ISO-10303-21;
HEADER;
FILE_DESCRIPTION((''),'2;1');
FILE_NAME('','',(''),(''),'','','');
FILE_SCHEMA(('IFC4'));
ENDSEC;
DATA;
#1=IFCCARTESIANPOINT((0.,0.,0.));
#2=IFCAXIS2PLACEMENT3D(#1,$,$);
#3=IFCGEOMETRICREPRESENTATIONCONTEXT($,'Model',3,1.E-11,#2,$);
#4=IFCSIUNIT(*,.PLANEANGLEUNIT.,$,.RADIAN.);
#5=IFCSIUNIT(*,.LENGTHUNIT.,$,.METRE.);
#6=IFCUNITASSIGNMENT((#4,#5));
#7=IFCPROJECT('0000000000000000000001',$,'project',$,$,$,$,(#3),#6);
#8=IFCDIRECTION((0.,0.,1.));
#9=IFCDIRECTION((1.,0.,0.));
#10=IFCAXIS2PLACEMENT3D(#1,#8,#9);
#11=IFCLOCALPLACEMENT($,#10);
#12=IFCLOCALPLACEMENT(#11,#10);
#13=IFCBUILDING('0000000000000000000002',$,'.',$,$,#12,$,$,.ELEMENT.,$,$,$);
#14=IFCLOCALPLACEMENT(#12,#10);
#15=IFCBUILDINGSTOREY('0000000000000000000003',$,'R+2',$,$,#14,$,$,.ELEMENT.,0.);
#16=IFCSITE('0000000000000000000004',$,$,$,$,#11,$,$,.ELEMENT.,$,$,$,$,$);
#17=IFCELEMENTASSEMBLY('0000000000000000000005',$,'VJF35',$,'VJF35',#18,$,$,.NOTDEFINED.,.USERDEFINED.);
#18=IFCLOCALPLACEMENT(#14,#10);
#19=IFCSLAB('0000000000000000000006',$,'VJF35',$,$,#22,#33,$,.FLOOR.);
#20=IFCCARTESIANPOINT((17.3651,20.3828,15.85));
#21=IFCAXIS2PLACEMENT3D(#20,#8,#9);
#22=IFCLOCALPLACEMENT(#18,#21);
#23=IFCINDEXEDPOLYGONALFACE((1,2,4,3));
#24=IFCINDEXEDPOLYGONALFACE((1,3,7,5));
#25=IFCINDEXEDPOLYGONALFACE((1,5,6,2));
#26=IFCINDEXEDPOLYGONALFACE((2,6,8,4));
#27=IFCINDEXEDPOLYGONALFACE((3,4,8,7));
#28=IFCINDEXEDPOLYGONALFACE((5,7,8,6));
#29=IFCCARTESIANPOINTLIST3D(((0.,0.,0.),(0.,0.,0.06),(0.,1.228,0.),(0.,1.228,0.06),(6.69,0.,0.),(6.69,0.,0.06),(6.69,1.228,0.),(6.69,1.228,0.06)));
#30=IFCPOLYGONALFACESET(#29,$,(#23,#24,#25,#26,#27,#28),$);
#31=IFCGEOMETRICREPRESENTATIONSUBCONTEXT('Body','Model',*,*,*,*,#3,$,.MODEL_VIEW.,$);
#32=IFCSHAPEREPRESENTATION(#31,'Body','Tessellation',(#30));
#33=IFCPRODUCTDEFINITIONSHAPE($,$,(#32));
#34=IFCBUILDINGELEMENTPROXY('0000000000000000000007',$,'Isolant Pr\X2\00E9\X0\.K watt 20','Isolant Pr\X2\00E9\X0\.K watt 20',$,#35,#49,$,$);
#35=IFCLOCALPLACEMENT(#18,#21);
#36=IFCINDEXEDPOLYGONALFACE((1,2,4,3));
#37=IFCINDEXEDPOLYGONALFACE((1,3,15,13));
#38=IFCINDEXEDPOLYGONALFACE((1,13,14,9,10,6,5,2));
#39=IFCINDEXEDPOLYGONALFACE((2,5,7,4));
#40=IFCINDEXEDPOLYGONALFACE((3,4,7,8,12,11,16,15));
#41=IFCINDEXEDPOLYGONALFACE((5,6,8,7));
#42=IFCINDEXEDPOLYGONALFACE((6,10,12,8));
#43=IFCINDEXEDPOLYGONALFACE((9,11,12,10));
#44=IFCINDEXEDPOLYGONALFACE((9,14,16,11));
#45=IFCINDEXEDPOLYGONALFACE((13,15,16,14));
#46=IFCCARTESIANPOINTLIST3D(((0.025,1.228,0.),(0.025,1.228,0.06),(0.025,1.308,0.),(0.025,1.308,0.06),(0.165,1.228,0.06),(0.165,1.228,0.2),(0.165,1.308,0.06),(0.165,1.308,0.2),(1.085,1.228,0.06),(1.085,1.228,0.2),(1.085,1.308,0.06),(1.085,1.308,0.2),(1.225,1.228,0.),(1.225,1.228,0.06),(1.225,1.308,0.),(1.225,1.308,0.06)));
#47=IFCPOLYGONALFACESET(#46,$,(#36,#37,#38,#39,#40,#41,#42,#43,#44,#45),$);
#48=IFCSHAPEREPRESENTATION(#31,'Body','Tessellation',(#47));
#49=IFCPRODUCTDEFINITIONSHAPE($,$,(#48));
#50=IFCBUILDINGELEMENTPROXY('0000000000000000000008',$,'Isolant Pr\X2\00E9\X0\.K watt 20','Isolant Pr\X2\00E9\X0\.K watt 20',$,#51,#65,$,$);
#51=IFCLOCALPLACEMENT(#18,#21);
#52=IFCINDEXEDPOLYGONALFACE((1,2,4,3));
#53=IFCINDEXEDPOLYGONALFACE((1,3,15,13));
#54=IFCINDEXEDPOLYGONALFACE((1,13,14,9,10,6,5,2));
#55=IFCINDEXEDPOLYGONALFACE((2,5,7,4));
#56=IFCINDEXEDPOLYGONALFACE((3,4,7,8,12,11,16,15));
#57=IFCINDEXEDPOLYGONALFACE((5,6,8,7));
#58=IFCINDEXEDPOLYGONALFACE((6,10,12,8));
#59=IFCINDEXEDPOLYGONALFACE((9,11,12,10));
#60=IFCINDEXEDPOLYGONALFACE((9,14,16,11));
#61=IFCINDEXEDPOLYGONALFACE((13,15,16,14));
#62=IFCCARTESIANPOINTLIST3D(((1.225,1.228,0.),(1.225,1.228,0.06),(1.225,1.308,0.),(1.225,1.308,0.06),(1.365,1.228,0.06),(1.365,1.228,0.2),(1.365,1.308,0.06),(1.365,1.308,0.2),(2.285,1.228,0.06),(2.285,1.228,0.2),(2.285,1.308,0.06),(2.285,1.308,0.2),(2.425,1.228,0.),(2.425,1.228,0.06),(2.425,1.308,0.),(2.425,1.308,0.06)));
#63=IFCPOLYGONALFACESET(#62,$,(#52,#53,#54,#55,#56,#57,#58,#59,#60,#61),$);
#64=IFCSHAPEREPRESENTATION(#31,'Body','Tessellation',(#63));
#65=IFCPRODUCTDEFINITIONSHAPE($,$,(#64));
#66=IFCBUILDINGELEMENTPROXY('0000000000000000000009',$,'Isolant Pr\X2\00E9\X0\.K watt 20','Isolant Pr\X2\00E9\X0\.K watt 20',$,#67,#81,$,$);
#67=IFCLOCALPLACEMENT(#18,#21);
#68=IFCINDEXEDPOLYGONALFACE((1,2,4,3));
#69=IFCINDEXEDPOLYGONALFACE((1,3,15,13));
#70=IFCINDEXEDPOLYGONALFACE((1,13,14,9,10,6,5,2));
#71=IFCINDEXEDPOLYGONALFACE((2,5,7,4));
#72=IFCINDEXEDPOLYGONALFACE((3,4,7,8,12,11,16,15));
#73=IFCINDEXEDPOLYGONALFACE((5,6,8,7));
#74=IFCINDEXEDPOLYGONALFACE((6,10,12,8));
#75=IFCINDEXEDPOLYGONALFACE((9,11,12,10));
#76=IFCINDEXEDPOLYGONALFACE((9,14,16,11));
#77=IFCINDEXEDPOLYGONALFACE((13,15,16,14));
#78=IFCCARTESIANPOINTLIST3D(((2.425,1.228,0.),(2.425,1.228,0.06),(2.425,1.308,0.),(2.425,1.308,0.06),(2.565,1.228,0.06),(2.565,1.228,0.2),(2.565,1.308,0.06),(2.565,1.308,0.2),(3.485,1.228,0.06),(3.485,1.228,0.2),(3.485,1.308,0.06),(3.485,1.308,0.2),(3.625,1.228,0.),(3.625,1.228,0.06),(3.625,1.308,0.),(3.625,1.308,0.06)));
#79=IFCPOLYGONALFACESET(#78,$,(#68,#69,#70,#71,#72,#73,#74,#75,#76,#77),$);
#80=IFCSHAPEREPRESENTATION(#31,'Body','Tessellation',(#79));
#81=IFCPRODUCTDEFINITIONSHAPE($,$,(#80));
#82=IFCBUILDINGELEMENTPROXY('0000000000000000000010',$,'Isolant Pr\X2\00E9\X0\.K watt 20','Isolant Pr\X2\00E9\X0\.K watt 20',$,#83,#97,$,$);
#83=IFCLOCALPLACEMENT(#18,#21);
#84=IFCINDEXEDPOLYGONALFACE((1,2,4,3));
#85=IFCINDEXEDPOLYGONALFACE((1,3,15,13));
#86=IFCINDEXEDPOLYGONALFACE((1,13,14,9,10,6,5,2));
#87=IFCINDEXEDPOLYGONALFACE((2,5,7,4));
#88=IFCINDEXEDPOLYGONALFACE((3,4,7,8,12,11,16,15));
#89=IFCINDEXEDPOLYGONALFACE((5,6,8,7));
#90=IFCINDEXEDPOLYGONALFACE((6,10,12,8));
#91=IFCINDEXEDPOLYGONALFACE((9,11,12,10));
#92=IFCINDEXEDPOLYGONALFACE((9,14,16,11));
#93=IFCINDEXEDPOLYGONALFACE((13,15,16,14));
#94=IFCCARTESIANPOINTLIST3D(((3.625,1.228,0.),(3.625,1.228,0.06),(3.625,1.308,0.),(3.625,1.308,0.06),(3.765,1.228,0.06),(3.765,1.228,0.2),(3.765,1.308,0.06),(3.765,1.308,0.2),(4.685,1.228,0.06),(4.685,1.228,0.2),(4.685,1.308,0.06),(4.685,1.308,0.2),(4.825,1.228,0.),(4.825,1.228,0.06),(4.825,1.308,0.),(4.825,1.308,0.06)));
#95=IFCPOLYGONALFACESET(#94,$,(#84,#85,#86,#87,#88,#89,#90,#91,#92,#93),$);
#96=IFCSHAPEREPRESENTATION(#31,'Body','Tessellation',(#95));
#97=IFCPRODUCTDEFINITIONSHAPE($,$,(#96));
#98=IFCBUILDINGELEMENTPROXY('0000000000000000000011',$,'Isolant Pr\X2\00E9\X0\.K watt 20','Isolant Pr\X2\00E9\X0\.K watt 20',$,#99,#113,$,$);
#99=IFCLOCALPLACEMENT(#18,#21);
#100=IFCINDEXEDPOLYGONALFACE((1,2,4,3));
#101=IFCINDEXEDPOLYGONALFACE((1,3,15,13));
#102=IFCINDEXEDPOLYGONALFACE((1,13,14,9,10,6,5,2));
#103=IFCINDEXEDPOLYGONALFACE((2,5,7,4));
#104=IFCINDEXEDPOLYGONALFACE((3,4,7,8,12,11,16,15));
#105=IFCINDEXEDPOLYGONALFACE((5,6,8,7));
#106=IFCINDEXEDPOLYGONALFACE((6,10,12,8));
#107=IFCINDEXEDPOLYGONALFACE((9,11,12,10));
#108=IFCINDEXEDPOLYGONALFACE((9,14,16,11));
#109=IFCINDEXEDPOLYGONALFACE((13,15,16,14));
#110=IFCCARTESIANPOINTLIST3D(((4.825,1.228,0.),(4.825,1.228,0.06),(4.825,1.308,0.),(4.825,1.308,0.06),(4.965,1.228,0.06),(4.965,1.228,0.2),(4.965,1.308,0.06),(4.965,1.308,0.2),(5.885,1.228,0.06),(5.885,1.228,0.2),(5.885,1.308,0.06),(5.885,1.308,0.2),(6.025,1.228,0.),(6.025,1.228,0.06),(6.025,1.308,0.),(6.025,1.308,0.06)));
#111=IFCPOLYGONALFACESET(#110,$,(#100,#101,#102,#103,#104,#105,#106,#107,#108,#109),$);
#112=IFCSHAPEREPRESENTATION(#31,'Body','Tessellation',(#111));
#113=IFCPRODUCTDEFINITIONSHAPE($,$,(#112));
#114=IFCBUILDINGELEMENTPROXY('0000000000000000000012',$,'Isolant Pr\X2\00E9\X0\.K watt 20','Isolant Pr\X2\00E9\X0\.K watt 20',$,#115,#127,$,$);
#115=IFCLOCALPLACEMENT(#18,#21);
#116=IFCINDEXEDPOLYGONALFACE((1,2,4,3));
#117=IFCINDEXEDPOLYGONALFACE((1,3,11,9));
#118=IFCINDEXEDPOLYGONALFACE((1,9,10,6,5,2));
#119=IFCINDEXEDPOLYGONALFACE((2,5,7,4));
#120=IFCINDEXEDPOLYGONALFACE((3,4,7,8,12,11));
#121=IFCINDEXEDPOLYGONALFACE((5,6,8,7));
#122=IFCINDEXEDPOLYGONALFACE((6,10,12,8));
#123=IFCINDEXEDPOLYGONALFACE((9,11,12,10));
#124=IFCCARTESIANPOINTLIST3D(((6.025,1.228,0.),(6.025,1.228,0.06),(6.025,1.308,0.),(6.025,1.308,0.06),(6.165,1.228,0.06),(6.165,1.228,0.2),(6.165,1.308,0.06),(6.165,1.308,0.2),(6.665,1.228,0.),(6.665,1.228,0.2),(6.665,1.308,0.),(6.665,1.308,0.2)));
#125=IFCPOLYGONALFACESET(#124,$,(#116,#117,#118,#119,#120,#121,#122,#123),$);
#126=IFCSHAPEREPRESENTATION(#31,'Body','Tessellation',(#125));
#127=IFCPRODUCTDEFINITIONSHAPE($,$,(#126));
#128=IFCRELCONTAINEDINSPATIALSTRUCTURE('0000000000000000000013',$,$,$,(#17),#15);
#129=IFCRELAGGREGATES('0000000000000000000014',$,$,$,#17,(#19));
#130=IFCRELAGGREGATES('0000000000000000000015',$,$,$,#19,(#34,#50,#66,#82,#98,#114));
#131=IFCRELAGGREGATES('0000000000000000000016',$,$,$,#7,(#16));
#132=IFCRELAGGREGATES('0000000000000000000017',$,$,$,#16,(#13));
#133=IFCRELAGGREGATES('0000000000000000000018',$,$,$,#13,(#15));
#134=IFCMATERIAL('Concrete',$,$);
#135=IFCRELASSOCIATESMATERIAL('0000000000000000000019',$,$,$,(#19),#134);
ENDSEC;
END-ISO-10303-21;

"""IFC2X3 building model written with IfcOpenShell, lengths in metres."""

from ifc_helpers import new_model, si_unit, frame, origin, origin_with_axes, place, context, subcontext, project, spatial, polyline, outline, extrude, material, element, aggregate, save


model = new_model("IFC2X3")

# Units and contexts
model_context = context("Model", 3, precision=1e-11, world=origin())
body_context = subcontext(model_context, "Body", "Model", "MODEL_VIEW")
ifc_project = project(units=[si_unit("PLANEANGLEUNIT", "RADIAN"), si_unit("LENGTHUNIT", "METRE")], contexts=[model_context])

# Site, building, storey
site_placement = place(None, origin_with_axes())
site = spatial("IfcSite", under=ifc_project, at=site_placement, CompositionType="ELEMENT")
building_placement = place(site_placement, origin_with_axes())
building = spatial("IfcBuilding", under=site, at=building_placement, Name=".", CompositionType="ELEMENT")
storey_placement = place(building_placement, origin_with_axes())
storey = spatial("IfcBuildingStorey", under=building, at=storey_placement, Name="R+2", CompositionType="ELEMENT", Elevation=0.0)

# Shared definitions
ifc_material = material(Name="Concrete")

# Element assembly, slab
assembly_1_placement = place(storey_placement, origin_with_axes())
assembly_1 = element("IfcElementAssembly", 1, at=assembly_1_placement, inside=storey, Name="VJF35", ObjectType="VJF35", AssemblyPlace="NOTDEFINED", PredefinedType="USERDEFINED")
slab_1_placement = place(assembly_1_placement, frame((17.3651, 20.3828, 15.85), z_axis=(0.0, 0.0, 1.0), x_axis=(1.0, 0.0, 0.0)))
slab_1 = element("IfcSlab", 2, at=slab_1_placement, material=ifc_material, Name="VJF35", PredefinedType="FLOOR", context=body_context, shape_type="SweptSolid", body=[
    extrude(outline(polyline([(0.0, 0.0), (0.0, -6.69), (1.228, -6.69), (1.228, 0.0), (0.0, 0.0)])), frame((0.0, 0.0, 0.0), z_axis=(0.0, 0.0, 1.0), x_axis=(0.0, 1.0, 0.0)), (0.0, 0.0, 1.0), 0.06),
])
aggregate(assembly_1, [slab_1])

# Building element proxies, openings
proxy_1_placement = place(assembly_1_placement, frame((17.3651, 20.3828, 15.85), z_axis=(0.0, 0.0, 1.0), x_axis=(1.0, 0.0, 0.0)))
proxy_1 = element("IfcBuildingElementProxy", 3, at=proxy_1_placement, Name="Isolant Pré.K watt 20", Description="Isolant Pré.K watt 20", context=body_context, shape_type="SweptSolid", body=[
    extrude(outline(polyline([(1.228, -0.025), (1.228, -1.225), (1.308, -1.225), (1.308, -0.025), (1.228, -0.025)])), frame((0.0, 0.0, 0.0), z_axis=(0.0, 0.0, 1.0), x_axis=(0.0, 1.0, 0.0)), (0.0, 0.0, 1.0), 0.2),
])
opening_1_placement = place(proxy_1_placement, frame((0.025, 1.228, 0.06), z_axis=(0.0, 0.0, 1.0), x_axis=(1.0, 0.0, 0.0)))
element("IfcOpeningElement", 4, at=opening_1_placement, cuts=proxy_1, context=body_context, shape_type="SweptSolid", body=[
    extrude(outline(polyline([(0.0, 0.0), (0.0, -0.14), (0.08, -0.14), (0.08, 0.0), (0.0, 0.0)])), frame((0.0, 0.0, 0.0), z_axis=(0.0, 0.0, 1.0), x_axis=(0.0, 1.0, 0.0)), (0.0, 0.0, 1.0), 0.14),
])
opening_2_placement = place(proxy_1_placement, frame((1.225, 1.308, 0.06), z_axis=(0.0, 0.0, 1.0), x_axis=(-1.0, 0.0, 0.0)))
element("IfcOpeningElement", 5, at=opening_2_placement, cuts=proxy_1, context=body_context, shape_type="SweptSolid", body=[
    extrude(outline(polyline([(0.0, 0.0), (0.0, -0.14), (0.08, -0.14), (0.08, 0.0), (0.0, 0.0)])), frame((0.0, 0.0, 0.0), z_axis=(0.0, 0.0, 1.0), x_axis=(0.0, 1.0, 0.0)), (0.0, 0.0, 1.0), 0.14),
])
proxy_2_placement = place(assembly_1_placement, frame((17.3651, 20.3828, 15.85), z_axis=(0.0, 0.0, 1.0), x_axis=(1.0, 0.0, 0.0)))
proxy_2 = element("IfcBuildingElementProxy", 6, at=proxy_2_placement, Name="Isolant Pré.K watt 20", Description="Isolant Pré.K watt 20", context=body_context, shape_type="SweptSolid", body=[
    extrude(outline(polyline([(1.228, -1.225), (1.228, -2.425), (1.308, -2.425), (1.308, -1.225), (1.228, -1.225)])), frame((0.0, 0.0, 0.0), z_axis=(0.0, 0.0, 1.0), x_axis=(0.0, 1.0, 0.0)), (0.0, 0.0, 1.0), 0.2),
])
opening_3_placement = place(proxy_2_placement, frame((1.225, 1.228, 0.06), z_axis=(0.0, 0.0, 1.0), x_axis=(1.0, 0.0, 0.0)))
element("IfcOpeningElement", 7, at=opening_3_placement, cuts=proxy_2, context=body_context, shape_type="SweptSolid", body=[
    extrude(outline(polyline([(0.0, 0.0), (0.0, -0.14), (0.08, -0.14), (0.08, 0.0), (0.0, 0.0)])), frame((0.0, 0.0, 0.0), z_axis=(0.0, 0.0, 1.0), x_axis=(0.0, 1.0, 0.0)), (0.0, 0.0, 1.0), 0.14),
])
opening_4_placement = place(proxy_2_placement, frame((2.425, 1.308, 0.06), z_axis=(0.0, 0.0, 1.0), x_axis=(-1.0, 0.0, 0.0)))
element("IfcOpeningElement", 8, at=opening_4_placement, cuts=proxy_2, context=body_context, shape_type="SweptSolid", body=[
    extrude(outline(polyline([(0.0, 0.0), (0.0, -0.14), (0.08, -0.14), (0.08, 0.0), (0.0, 0.0)])), frame((0.0, 0.0, 0.0), z_axis=(0.0, 0.0, 1.0), x_axis=(0.0, 1.0, 0.0)), (0.0, 0.0, 1.0), 0.14),
])
proxy_3_placement = place(assembly_1_placement, frame((17.3651, 20.3828, 15.85), z_axis=(0.0, 0.0, 1.0), x_axis=(1.0, 0.0, 0.0)))
proxy_3 = element("IfcBuildingElementProxy", 9, at=proxy_3_placement, Name="Isolant Pré.K watt 20", Description="Isolant Pré.K watt 20", context=body_context, shape_type="SweptSolid", body=[
    extrude(outline(polyline([(1.228, -2.425), (1.228, -3.625), (1.308, -3.625), (1.308, -2.425), (1.228, -2.425)])), frame((0.0, 0.0, 0.0), z_axis=(0.0, 0.0, 1.0), x_axis=(0.0, 1.0, 0.0)), (0.0, 0.0, 1.0), 0.2),
])
opening_5_placement = place(proxy_3_placement, frame((2.425, 1.228, 0.06), z_axis=(0.0, 0.0, 1.0), x_axis=(1.0, 0.0, 0.0)))
element("IfcOpeningElement", 10, at=opening_5_placement, cuts=proxy_3, context=body_context, shape_type="SweptSolid", body=[
    extrude(outline(polyline([(0.0, 0.0), (0.0, -0.14), (0.08, -0.14), (0.08, 0.0), (0.0, 0.0)])), frame((0.0, 0.0, 0.0), z_axis=(0.0, 0.0, 1.0), x_axis=(0.0, 1.0, 0.0)), (0.0, 0.0, 1.0), 0.14),
])
opening_6_placement = place(proxy_3_placement, frame((3.625, 1.308, 0.06), z_axis=(0.0, 0.0, 1.0), x_axis=(-1.0, 0.0, 0.0)))
element("IfcOpeningElement", 11, at=opening_6_placement, cuts=proxy_3, context=body_context, shape_type="SweptSolid", body=[
    extrude(outline(polyline([(0.0, 0.0), (0.0, -0.14), (0.08, -0.14), (0.08, 0.0), (0.0, 0.0)])), frame((0.0, 0.0, 0.0), z_axis=(0.0, 0.0, 1.0), x_axis=(0.0, 1.0, 0.0)), (0.0, 0.0, 1.0), 0.14),
])
proxy_4_placement = place(assembly_1_placement, frame((17.3651, 20.3828, 15.85), z_axis=(0.0, 0.0, 1.0), x_axis=(1.0, 0.0, 0.0)))
proxy_4 = element("IfcBuildingElementProxy", 12, at=proxy_4_placement, Name="Isolant Pré.K watt 20", Description="Isolant Pré.K watt 20", context=body_context, shape_type="SweptSolid", body=[
    extrude(outline(polyline([(1.228, -3.625), (1.228, -4.825), (1.308, -4.825), (1.308, -3.625), (1.228, -3.625)])), frame((0.0, 0.0, 0.0), z_axis=(0.0, 0.0, 1.0), x_axis=(0.0, 1.0, 0.0)), (0.0, 0.0, 1.0), 0.2),
])
opening_7_placement = place(proxy_4_placement, frame((3.625, 1.228, 0.06), z_axis=(0.0, 0.0, 1.0), x_axis=(1.0, 0.0, 0.0)))
element("IfcOpeningElement", 13, at=opening_7_placement, cuts=proxy_4, context=body_context, shape_type="SweptSolid", body=[
    extrude(outline(polyline([(0.0, 0.0), (0.0, -0.14), (0.08, -0.14), (0.08, 0.0), (0.0, 0.0)])), frame((0.0, 0.0, 0.0), z_axis=(0.0, 0.0, 1.0), x_axis=(0.0, 1.0, 0.0)), (0.0, 0.0, 1.0), 0.14),
])
opening_8_placement = place(proxy_4_placement, frame((4.825, 1.308, 0.06), z_axis=(0.0, 0.0, 1.0), x_axis=(-1.0, 0.0, 0.0)))
element("IfcOpeningElement", 14, at=opening_8_placement, cuts=proxy_4, context=body_context, shape_type="SweptSolid", body=[
    extrude(outline(polyline([(0.0, 0.0), (0.0, -0.14), (0.08, -0.14), (0.08, 0.0), (0.0, 0.0)])), frame((0.0, 0.0, 0.0), z_axis=(0.0, 0.0, 1.0), x_axis=(0.0, 1.0, 0.0)), (0.0, 0.0, 1.0), 0.14),
])
proxy_5_placement = place(assembly_1_placement, frame((17.3651, 20.3828, 15.85), z_axis=(0.0, 0.0, 1.0), x_axis=(1.0, 0.0, 0.0)))
proxy_5 = element("IfcBuildingElementProxy", 15, at=proxy_5_placement, Name="Isolant Pré.K watt 20", Description="Isolant Pré.K watt 20", context=body_context, shape_type="SweptSolid", body=[
    extrude(outline(polyline([(1.228, -4.825), (1.228, -6.025), (1.308, -6.025), (1.308, -4.825), (1.228, -4.825)])), frame((0.0, 0.0, 0.0), z_axis=(0.0, 0.0, 1.0), x_axis=(0.0, 1.0, 0.0)), (0.0, 0.0, 1.0), 0.2),
])
opening_9_placement = place(proxy_5_placement, frame((4.825, 1.228, 0.06), z_axis=(0.0, 0.0, 1.0), x_axis=(1.0, 0.0, 0.0)))
element("IfcOpeningElement", 16, at=opening_9_placement, cuts=proxy_5, context=body_context, shape_type="SweptSolid", body=[
    extrude(outline(polyline([(0.0, 0.0), (0.0, -0.14), (0.08, -0.14), (0.08, 0.0), (0.0, 0.0)])), frame((0.0, 0.0, 0.0), z_axis=(0.0, 0.0, 1.0), x_axis=(0.0, 1.0, 0.0)), (0.0, 0.0, 1.0), 0.14),
])
opening_10_placement = place(proxy_5_placement, frame((6.025, 1.308, 0.06), z_axis=(0.0, 0.0, 1.0), x_axis=(-1.0, 0.0, 0.0)))
element("IfcOpeningElement", 17, at=opening_10_placement, cuts=proxy_5, context=body_context, shape_type="SweptSolid", body=[
    extrude(outline(polyline([(0.0, 0.0), (0.0, -0.14), (0.08, -0.14), (0.08, 0.0), (0.0, 0.0)])), frame((0.0, 0.0, 0.0), z_axis=(0.0, 0.0, 1.0), x_axis=(0.0, 1.0, 0.0)), (0.0, 0.0, 1.0), 0.14),
])

# Building element proxy, opening
proxy_6_placement = place(assembly_1_placement, frame((17.3651, 20.3828, 15.85), z_axis=(0.0, 0.0, 1.0), x_axis=(1.0, 0.0, 0.0)))
proxy_6 = element("IfcBuildingElementProxy", 18, at=proxy_6_placement, Name="Isolant Pré.K watt 20", Description="Isolant Pré.K watt 20", context=body_context, shape_type="SweptSolid", body=[
    extrude(outline(polyline([(1.228, -6.025), (1.228, -6.665), (1.308, -6.665), (1.308, -6.025), (1.228, -6.025)])), frame((0.0, 0.0, 0.0), z_axis=(0.0, 0.0, 1.0), x_axis=(0.0, 1.0, 0.0)), (0.0, 0.0, 1.0), 0.2),
])
opening_11_placement = place(proxy_6_placement, frame((6.025, 1.228, 0.06), z_axis=(0.0, 0.0, 1.0), x_axis=(1.0, 0.0, 0.0)))
element("IfcOpeningElement", 19, at=opening_11_placement, cuts=proxy_6, context=body_context, shape_type="SweptSolid", body=[
    extrude(outline(polyline([(0.0, 0.0), (0.0, -0.14), (0.08, -0.14), (0.08, 0.0), (0.0, 0.0)])), frame((0.0, 0.0, 0.0), z_axis=(0.0, 0.0, 1.0), x_axis=(0.0, 1.0, 0.0)), (0.0, 0.0, 1.0), 0.14),
])
aggregate(slab_1, [proxy_1, proxy_2, proxy_3, proxy_4, proxy_5, proxy_6])

save(model, "model.ifc")
